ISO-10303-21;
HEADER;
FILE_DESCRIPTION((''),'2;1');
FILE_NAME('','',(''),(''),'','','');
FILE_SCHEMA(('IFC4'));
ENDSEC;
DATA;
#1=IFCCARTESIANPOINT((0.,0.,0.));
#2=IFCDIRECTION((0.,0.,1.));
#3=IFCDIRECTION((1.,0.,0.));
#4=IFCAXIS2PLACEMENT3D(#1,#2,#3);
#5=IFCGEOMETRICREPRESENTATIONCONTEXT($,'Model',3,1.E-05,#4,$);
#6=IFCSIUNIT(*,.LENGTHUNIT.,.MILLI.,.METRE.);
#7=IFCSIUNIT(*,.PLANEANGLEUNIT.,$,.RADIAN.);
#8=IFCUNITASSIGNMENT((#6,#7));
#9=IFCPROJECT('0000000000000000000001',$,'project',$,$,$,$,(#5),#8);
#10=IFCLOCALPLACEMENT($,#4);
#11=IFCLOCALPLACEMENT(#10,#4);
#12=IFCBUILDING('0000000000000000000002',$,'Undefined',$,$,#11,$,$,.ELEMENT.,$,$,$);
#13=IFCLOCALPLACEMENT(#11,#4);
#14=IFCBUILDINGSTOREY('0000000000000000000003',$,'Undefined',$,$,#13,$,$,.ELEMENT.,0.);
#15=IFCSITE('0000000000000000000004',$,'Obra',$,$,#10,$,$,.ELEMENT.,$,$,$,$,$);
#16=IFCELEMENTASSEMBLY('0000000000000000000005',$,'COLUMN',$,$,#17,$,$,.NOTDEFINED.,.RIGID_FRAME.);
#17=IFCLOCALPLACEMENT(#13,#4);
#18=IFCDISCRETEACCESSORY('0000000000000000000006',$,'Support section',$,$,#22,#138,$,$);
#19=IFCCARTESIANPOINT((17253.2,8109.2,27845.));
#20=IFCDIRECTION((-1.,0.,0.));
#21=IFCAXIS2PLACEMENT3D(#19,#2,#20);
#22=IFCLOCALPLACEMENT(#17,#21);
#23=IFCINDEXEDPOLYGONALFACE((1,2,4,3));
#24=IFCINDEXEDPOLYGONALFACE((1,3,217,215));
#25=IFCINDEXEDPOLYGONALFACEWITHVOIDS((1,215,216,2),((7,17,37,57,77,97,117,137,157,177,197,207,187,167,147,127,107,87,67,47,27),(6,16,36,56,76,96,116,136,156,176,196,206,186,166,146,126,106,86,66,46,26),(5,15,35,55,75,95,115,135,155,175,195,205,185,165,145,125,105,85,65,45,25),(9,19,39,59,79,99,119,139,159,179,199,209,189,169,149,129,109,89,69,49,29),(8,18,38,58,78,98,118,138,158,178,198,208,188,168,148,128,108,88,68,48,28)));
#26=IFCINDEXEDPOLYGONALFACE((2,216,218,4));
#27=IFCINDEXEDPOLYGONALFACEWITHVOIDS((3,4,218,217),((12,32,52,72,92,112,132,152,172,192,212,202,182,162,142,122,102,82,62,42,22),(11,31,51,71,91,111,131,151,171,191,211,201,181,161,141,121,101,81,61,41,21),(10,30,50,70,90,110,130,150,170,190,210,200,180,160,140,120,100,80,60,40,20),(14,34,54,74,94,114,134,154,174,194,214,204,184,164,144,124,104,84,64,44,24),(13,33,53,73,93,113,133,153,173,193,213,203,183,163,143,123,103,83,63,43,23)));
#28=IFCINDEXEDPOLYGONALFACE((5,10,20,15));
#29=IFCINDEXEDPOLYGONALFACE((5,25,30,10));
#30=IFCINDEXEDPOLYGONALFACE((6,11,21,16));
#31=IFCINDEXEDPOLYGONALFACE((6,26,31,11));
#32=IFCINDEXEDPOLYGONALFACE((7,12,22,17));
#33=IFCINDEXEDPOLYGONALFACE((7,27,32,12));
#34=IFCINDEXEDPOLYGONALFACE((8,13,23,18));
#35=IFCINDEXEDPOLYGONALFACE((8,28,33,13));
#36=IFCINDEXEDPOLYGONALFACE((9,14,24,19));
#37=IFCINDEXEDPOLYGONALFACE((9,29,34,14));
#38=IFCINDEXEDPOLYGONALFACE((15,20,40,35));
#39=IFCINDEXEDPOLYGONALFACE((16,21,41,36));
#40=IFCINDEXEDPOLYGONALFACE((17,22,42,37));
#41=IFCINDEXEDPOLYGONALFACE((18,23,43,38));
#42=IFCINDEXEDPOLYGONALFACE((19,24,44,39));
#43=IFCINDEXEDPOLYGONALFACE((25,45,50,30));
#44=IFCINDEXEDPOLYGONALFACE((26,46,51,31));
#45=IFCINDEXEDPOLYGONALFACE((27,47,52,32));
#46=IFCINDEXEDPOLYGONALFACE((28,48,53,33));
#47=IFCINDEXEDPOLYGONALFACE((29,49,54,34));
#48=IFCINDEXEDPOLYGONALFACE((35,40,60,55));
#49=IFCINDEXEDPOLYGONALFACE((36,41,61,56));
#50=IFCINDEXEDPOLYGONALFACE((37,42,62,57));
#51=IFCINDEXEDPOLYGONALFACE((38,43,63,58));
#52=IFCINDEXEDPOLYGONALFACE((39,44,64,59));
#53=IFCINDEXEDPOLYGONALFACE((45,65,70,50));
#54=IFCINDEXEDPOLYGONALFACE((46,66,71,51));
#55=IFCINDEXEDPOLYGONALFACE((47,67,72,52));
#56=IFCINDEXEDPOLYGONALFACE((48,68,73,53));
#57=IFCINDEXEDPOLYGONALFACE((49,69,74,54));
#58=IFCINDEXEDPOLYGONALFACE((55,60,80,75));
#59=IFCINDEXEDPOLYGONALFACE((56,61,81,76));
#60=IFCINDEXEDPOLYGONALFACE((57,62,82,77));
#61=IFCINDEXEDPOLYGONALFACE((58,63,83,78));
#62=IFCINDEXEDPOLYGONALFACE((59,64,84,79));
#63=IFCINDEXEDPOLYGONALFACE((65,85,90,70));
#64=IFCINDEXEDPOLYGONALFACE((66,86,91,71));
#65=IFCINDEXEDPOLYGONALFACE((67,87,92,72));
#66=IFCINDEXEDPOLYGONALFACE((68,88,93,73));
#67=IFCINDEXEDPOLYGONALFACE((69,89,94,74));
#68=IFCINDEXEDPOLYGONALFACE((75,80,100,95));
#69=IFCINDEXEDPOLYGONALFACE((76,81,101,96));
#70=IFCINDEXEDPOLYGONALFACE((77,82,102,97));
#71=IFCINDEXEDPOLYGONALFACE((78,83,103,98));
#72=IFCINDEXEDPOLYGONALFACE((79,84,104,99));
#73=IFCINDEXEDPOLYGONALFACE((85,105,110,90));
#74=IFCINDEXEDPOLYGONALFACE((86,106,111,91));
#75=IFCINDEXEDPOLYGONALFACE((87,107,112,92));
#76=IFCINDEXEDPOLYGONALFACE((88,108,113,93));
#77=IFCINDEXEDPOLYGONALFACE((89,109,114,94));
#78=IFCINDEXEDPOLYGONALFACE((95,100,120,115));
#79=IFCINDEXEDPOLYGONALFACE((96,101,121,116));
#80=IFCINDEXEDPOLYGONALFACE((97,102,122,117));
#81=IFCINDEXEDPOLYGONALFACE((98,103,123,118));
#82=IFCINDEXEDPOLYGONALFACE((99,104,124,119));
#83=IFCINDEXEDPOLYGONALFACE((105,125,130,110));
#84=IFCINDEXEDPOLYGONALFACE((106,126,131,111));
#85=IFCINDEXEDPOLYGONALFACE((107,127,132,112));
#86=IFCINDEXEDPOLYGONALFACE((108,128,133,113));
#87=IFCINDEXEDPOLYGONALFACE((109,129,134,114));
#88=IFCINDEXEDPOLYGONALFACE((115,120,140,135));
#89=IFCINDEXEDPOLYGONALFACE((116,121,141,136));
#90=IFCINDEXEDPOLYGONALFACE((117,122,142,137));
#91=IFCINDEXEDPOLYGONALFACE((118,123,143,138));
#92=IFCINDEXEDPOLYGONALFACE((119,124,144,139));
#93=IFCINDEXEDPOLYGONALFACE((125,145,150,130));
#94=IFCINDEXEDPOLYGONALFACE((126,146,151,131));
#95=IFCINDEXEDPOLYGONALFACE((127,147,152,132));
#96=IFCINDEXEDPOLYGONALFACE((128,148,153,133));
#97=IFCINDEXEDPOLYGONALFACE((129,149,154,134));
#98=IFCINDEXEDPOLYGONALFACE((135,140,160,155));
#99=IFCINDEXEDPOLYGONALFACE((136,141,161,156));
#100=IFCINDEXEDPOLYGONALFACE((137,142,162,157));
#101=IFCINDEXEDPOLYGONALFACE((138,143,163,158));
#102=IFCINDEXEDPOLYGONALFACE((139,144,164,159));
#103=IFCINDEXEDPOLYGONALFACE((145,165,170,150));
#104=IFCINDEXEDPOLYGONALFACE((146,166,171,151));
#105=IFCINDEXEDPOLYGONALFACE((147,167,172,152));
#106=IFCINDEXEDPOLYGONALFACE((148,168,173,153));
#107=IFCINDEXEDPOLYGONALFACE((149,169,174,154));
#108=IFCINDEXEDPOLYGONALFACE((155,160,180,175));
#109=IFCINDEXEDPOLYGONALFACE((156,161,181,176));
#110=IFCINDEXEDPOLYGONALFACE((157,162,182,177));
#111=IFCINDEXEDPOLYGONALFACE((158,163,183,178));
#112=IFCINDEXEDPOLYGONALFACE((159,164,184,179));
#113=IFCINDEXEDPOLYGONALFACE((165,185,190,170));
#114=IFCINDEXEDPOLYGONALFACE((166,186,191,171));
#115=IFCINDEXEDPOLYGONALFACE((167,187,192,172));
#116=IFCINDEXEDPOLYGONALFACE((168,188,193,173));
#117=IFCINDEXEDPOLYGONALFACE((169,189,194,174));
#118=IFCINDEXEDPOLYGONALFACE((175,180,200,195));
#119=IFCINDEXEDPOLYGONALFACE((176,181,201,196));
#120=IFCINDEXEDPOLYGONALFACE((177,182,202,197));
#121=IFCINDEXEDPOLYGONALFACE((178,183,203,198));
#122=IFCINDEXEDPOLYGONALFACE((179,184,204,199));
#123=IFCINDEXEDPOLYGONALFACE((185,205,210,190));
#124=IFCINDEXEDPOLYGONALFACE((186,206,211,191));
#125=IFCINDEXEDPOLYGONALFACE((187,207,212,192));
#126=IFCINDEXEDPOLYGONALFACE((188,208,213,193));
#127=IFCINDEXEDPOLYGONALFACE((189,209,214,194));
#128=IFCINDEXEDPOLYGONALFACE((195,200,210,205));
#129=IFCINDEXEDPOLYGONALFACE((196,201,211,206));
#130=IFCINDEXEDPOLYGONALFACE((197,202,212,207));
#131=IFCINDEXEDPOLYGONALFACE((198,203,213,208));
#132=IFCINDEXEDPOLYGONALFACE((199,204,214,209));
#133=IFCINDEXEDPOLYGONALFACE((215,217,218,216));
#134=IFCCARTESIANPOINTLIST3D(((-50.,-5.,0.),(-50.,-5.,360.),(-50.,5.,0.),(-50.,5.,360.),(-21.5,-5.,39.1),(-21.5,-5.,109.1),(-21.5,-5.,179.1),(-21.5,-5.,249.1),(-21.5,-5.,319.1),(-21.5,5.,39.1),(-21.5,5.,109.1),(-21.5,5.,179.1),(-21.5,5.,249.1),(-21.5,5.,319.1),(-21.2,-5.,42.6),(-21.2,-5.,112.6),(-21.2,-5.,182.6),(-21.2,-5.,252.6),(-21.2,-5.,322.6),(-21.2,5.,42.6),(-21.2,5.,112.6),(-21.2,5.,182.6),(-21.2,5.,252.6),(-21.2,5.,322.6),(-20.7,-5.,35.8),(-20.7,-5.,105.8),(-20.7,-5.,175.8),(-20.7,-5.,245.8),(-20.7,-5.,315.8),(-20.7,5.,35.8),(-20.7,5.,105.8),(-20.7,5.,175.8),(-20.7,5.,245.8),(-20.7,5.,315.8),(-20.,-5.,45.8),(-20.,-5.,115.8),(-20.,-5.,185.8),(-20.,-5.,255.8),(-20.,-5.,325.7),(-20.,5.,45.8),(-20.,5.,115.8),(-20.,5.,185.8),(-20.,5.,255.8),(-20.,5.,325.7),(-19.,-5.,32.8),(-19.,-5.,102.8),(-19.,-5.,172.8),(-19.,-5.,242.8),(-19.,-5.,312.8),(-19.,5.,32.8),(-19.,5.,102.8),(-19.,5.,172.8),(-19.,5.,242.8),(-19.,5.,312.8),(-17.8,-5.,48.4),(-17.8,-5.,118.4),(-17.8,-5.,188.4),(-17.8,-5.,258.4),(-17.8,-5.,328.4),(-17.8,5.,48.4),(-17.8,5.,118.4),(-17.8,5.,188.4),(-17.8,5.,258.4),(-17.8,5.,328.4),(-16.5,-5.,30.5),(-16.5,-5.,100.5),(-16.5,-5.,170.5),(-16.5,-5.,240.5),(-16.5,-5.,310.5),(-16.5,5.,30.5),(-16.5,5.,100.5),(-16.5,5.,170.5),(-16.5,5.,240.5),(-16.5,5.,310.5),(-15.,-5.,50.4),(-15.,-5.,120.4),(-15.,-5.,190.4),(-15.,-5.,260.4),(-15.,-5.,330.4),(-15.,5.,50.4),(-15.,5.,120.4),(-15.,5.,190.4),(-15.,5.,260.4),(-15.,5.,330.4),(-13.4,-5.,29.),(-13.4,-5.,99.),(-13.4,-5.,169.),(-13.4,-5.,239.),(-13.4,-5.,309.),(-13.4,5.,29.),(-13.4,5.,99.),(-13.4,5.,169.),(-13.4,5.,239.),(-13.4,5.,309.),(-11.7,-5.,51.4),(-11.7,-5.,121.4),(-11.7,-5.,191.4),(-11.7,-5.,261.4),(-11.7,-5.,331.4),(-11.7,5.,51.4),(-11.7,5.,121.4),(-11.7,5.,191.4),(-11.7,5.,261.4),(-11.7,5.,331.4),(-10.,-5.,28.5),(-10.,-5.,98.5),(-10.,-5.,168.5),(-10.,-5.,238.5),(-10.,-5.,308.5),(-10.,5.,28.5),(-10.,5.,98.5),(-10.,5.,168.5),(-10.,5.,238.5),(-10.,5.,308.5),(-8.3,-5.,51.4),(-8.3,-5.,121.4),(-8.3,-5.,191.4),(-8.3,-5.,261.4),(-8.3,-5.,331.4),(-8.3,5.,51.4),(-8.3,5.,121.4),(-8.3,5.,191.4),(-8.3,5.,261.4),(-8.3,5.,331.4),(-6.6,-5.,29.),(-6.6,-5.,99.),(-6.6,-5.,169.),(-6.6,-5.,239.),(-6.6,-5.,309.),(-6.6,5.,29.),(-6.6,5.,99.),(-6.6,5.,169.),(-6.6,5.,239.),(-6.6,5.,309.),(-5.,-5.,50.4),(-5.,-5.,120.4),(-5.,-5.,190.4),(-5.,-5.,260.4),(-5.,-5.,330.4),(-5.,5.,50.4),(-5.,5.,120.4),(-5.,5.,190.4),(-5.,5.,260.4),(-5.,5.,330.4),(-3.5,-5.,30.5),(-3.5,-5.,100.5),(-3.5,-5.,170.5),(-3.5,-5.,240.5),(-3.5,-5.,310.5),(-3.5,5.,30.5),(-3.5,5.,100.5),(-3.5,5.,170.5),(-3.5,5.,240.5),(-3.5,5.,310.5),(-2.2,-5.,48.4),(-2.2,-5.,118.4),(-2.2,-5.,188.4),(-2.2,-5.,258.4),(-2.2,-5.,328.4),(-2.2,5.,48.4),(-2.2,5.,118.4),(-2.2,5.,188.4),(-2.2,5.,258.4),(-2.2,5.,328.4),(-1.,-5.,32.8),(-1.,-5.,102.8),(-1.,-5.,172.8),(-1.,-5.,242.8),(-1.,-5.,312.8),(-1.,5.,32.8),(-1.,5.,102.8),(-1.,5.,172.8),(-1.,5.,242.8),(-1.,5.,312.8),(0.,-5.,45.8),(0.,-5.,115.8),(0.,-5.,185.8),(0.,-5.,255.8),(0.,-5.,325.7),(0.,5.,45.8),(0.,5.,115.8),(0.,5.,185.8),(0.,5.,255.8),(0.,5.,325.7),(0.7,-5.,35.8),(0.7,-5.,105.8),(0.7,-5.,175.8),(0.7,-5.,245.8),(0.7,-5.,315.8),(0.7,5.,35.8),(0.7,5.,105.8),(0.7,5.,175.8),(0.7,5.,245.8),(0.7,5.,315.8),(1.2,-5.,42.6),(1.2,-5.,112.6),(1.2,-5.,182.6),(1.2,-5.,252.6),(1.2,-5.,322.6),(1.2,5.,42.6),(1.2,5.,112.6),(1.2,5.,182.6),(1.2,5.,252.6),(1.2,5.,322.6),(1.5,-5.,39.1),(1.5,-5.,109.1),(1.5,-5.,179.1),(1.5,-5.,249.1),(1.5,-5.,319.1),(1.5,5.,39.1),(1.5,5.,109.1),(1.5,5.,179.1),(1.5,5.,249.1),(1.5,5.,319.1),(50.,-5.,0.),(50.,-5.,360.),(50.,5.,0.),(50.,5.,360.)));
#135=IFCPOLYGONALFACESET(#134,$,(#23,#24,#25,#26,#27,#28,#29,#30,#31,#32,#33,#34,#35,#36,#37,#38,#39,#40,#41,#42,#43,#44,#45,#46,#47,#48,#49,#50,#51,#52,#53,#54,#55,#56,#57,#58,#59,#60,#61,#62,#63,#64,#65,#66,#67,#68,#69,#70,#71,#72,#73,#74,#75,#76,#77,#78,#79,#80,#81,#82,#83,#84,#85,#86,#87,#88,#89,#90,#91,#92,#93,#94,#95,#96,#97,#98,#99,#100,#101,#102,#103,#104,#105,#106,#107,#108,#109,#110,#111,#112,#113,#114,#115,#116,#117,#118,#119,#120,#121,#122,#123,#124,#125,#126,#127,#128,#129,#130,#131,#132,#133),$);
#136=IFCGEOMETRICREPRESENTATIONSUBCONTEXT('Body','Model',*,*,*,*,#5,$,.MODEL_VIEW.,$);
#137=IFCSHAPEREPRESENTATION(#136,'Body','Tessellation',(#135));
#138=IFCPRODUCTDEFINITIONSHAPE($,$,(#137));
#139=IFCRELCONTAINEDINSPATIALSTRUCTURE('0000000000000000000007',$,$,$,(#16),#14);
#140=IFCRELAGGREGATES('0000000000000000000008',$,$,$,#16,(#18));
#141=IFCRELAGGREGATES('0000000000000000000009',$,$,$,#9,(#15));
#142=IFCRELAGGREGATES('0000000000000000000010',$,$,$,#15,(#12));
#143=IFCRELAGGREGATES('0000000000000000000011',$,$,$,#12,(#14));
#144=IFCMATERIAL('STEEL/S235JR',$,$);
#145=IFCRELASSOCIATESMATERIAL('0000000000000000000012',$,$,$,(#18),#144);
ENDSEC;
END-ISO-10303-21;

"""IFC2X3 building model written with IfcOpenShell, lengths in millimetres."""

from ifc_helpers import new_model, si_unit, frame, origin_with_axes, origin_2d_with_axis, place, context, subcontext, project, spatial, rectangle, circle, extrude, source, transform, mapped, material, element, aggregate, save


model = new_model("IFC2X3")

# Units and contexts
model_context = context("Model", 3, precision=1e-05, world=origin_with_axes())
body_context = subcontext(model_context, "Body", "Model", "MODEL_VIEW")
ifc_project = project(units=[si_unit("LENGTHUNIT", "METRE", prefix="MILLI"), si_unit("PLANEANGLEUNIT", "RADIAN")], contexts=[model_context])

# Site, building, storey
site_placement = place(None, origin_with_axes())
site = spatial("IfcSite", under=ifc_project, at=site_placement, Name="Obra", CompositionType="ELEMENT")
building_placement = place(site_placement, origin_with_axes())
building = spatial("IfcBuilding", under=site, at=building_placement, Name="Undefined", CompositionType="ELEMENT")
storey_placement = place(building_placement, origin_with_axes())
storey = spatial("IfcBuildingStorey", under=building, at=storey_placement, Name="Undefined", CompositionType="ELEMENT", Elevation=0.0)

# Element assembly
assembly_1_placement = place(storey_placement, origin_with_axes())
assembly_1 = element("IfcElementAssembly", 1, at=assembly_1_placement, inside=storey, Name="COLUMN", AssemblyPlace="NOTDEFINED", PredefinedType="RIGID_FRAME")
ifc_material_1 = material(Name="STEEL/S235JR")

# Discrete accessory, opening
discrete_accessory_1_placement = place(assembly_1_placement, frame((17253.2, 8109.2, 27845.0), z_axis=(0.0, 0.0, 1.0), x_axis=(-1.0, 0.0, 0.0)))
discrete_accessory_1 = element("IfcDiscreteAccessory", 2, at=discrete_accessory_1_placement, material=ifc_material_1, Name="Support section", context=body_context, shape_type="SweptSolid", body=[
    extrude(rectangle(XDim=10.0, YDim=100.0, at=origin_2d_with_axis()), frame((0.0, 0.0, 360.0), z_axis=(0.0, 0.0, -1.0), x_axis=(0.0, 1.0, 0.0)), (0.0, 0.0, 1.0), 360.0),
])
shared_shape_1 = source(origin_with_axes(), body_context, "Body", "SweptSolid", [
    extrude(circle(Radius=11.5, at=origin_2d_with_axis()), frame((0.0, -14.8, 0.0), z_axis=(0.0, 1.0, 0.0), x_axis=(1.0, 0.0, 0.0)), (0.0, 0.0, 1.0), 10.2),
])
opening_1_placement = place(assembly_1_placement, frame((17223.2, 8118.9, 28250.0), z_axis=(1.0, 0.0, 0.0), x_axis=(0.0, 0.0, -1.0)))
element("IfcOpeningElement", 3, at=opening_1_placement, cuts=discrete_accessory_1, ObjectType="Opening", context=body_context, shape_type="MappedRepresentation", body=[
    mapped(shared_shape_1, transform((85.0, 0.0, 40.0))),
    mapped(shared_shape_1, transform((155.0, 0.0, 40.0))),
    mapped(shared_shape_1, transform((225.0, 0.0, 40.0))),
    mapped(shared_shape_1, transform((295.0, 0.0, 40.0))),
    mapped(shared_shape_1, transform((365.0, 0.0, 40.0))),
])
aggregate(assembly_1, [discrete_accessory_1])

save(model, "model.ifc")
